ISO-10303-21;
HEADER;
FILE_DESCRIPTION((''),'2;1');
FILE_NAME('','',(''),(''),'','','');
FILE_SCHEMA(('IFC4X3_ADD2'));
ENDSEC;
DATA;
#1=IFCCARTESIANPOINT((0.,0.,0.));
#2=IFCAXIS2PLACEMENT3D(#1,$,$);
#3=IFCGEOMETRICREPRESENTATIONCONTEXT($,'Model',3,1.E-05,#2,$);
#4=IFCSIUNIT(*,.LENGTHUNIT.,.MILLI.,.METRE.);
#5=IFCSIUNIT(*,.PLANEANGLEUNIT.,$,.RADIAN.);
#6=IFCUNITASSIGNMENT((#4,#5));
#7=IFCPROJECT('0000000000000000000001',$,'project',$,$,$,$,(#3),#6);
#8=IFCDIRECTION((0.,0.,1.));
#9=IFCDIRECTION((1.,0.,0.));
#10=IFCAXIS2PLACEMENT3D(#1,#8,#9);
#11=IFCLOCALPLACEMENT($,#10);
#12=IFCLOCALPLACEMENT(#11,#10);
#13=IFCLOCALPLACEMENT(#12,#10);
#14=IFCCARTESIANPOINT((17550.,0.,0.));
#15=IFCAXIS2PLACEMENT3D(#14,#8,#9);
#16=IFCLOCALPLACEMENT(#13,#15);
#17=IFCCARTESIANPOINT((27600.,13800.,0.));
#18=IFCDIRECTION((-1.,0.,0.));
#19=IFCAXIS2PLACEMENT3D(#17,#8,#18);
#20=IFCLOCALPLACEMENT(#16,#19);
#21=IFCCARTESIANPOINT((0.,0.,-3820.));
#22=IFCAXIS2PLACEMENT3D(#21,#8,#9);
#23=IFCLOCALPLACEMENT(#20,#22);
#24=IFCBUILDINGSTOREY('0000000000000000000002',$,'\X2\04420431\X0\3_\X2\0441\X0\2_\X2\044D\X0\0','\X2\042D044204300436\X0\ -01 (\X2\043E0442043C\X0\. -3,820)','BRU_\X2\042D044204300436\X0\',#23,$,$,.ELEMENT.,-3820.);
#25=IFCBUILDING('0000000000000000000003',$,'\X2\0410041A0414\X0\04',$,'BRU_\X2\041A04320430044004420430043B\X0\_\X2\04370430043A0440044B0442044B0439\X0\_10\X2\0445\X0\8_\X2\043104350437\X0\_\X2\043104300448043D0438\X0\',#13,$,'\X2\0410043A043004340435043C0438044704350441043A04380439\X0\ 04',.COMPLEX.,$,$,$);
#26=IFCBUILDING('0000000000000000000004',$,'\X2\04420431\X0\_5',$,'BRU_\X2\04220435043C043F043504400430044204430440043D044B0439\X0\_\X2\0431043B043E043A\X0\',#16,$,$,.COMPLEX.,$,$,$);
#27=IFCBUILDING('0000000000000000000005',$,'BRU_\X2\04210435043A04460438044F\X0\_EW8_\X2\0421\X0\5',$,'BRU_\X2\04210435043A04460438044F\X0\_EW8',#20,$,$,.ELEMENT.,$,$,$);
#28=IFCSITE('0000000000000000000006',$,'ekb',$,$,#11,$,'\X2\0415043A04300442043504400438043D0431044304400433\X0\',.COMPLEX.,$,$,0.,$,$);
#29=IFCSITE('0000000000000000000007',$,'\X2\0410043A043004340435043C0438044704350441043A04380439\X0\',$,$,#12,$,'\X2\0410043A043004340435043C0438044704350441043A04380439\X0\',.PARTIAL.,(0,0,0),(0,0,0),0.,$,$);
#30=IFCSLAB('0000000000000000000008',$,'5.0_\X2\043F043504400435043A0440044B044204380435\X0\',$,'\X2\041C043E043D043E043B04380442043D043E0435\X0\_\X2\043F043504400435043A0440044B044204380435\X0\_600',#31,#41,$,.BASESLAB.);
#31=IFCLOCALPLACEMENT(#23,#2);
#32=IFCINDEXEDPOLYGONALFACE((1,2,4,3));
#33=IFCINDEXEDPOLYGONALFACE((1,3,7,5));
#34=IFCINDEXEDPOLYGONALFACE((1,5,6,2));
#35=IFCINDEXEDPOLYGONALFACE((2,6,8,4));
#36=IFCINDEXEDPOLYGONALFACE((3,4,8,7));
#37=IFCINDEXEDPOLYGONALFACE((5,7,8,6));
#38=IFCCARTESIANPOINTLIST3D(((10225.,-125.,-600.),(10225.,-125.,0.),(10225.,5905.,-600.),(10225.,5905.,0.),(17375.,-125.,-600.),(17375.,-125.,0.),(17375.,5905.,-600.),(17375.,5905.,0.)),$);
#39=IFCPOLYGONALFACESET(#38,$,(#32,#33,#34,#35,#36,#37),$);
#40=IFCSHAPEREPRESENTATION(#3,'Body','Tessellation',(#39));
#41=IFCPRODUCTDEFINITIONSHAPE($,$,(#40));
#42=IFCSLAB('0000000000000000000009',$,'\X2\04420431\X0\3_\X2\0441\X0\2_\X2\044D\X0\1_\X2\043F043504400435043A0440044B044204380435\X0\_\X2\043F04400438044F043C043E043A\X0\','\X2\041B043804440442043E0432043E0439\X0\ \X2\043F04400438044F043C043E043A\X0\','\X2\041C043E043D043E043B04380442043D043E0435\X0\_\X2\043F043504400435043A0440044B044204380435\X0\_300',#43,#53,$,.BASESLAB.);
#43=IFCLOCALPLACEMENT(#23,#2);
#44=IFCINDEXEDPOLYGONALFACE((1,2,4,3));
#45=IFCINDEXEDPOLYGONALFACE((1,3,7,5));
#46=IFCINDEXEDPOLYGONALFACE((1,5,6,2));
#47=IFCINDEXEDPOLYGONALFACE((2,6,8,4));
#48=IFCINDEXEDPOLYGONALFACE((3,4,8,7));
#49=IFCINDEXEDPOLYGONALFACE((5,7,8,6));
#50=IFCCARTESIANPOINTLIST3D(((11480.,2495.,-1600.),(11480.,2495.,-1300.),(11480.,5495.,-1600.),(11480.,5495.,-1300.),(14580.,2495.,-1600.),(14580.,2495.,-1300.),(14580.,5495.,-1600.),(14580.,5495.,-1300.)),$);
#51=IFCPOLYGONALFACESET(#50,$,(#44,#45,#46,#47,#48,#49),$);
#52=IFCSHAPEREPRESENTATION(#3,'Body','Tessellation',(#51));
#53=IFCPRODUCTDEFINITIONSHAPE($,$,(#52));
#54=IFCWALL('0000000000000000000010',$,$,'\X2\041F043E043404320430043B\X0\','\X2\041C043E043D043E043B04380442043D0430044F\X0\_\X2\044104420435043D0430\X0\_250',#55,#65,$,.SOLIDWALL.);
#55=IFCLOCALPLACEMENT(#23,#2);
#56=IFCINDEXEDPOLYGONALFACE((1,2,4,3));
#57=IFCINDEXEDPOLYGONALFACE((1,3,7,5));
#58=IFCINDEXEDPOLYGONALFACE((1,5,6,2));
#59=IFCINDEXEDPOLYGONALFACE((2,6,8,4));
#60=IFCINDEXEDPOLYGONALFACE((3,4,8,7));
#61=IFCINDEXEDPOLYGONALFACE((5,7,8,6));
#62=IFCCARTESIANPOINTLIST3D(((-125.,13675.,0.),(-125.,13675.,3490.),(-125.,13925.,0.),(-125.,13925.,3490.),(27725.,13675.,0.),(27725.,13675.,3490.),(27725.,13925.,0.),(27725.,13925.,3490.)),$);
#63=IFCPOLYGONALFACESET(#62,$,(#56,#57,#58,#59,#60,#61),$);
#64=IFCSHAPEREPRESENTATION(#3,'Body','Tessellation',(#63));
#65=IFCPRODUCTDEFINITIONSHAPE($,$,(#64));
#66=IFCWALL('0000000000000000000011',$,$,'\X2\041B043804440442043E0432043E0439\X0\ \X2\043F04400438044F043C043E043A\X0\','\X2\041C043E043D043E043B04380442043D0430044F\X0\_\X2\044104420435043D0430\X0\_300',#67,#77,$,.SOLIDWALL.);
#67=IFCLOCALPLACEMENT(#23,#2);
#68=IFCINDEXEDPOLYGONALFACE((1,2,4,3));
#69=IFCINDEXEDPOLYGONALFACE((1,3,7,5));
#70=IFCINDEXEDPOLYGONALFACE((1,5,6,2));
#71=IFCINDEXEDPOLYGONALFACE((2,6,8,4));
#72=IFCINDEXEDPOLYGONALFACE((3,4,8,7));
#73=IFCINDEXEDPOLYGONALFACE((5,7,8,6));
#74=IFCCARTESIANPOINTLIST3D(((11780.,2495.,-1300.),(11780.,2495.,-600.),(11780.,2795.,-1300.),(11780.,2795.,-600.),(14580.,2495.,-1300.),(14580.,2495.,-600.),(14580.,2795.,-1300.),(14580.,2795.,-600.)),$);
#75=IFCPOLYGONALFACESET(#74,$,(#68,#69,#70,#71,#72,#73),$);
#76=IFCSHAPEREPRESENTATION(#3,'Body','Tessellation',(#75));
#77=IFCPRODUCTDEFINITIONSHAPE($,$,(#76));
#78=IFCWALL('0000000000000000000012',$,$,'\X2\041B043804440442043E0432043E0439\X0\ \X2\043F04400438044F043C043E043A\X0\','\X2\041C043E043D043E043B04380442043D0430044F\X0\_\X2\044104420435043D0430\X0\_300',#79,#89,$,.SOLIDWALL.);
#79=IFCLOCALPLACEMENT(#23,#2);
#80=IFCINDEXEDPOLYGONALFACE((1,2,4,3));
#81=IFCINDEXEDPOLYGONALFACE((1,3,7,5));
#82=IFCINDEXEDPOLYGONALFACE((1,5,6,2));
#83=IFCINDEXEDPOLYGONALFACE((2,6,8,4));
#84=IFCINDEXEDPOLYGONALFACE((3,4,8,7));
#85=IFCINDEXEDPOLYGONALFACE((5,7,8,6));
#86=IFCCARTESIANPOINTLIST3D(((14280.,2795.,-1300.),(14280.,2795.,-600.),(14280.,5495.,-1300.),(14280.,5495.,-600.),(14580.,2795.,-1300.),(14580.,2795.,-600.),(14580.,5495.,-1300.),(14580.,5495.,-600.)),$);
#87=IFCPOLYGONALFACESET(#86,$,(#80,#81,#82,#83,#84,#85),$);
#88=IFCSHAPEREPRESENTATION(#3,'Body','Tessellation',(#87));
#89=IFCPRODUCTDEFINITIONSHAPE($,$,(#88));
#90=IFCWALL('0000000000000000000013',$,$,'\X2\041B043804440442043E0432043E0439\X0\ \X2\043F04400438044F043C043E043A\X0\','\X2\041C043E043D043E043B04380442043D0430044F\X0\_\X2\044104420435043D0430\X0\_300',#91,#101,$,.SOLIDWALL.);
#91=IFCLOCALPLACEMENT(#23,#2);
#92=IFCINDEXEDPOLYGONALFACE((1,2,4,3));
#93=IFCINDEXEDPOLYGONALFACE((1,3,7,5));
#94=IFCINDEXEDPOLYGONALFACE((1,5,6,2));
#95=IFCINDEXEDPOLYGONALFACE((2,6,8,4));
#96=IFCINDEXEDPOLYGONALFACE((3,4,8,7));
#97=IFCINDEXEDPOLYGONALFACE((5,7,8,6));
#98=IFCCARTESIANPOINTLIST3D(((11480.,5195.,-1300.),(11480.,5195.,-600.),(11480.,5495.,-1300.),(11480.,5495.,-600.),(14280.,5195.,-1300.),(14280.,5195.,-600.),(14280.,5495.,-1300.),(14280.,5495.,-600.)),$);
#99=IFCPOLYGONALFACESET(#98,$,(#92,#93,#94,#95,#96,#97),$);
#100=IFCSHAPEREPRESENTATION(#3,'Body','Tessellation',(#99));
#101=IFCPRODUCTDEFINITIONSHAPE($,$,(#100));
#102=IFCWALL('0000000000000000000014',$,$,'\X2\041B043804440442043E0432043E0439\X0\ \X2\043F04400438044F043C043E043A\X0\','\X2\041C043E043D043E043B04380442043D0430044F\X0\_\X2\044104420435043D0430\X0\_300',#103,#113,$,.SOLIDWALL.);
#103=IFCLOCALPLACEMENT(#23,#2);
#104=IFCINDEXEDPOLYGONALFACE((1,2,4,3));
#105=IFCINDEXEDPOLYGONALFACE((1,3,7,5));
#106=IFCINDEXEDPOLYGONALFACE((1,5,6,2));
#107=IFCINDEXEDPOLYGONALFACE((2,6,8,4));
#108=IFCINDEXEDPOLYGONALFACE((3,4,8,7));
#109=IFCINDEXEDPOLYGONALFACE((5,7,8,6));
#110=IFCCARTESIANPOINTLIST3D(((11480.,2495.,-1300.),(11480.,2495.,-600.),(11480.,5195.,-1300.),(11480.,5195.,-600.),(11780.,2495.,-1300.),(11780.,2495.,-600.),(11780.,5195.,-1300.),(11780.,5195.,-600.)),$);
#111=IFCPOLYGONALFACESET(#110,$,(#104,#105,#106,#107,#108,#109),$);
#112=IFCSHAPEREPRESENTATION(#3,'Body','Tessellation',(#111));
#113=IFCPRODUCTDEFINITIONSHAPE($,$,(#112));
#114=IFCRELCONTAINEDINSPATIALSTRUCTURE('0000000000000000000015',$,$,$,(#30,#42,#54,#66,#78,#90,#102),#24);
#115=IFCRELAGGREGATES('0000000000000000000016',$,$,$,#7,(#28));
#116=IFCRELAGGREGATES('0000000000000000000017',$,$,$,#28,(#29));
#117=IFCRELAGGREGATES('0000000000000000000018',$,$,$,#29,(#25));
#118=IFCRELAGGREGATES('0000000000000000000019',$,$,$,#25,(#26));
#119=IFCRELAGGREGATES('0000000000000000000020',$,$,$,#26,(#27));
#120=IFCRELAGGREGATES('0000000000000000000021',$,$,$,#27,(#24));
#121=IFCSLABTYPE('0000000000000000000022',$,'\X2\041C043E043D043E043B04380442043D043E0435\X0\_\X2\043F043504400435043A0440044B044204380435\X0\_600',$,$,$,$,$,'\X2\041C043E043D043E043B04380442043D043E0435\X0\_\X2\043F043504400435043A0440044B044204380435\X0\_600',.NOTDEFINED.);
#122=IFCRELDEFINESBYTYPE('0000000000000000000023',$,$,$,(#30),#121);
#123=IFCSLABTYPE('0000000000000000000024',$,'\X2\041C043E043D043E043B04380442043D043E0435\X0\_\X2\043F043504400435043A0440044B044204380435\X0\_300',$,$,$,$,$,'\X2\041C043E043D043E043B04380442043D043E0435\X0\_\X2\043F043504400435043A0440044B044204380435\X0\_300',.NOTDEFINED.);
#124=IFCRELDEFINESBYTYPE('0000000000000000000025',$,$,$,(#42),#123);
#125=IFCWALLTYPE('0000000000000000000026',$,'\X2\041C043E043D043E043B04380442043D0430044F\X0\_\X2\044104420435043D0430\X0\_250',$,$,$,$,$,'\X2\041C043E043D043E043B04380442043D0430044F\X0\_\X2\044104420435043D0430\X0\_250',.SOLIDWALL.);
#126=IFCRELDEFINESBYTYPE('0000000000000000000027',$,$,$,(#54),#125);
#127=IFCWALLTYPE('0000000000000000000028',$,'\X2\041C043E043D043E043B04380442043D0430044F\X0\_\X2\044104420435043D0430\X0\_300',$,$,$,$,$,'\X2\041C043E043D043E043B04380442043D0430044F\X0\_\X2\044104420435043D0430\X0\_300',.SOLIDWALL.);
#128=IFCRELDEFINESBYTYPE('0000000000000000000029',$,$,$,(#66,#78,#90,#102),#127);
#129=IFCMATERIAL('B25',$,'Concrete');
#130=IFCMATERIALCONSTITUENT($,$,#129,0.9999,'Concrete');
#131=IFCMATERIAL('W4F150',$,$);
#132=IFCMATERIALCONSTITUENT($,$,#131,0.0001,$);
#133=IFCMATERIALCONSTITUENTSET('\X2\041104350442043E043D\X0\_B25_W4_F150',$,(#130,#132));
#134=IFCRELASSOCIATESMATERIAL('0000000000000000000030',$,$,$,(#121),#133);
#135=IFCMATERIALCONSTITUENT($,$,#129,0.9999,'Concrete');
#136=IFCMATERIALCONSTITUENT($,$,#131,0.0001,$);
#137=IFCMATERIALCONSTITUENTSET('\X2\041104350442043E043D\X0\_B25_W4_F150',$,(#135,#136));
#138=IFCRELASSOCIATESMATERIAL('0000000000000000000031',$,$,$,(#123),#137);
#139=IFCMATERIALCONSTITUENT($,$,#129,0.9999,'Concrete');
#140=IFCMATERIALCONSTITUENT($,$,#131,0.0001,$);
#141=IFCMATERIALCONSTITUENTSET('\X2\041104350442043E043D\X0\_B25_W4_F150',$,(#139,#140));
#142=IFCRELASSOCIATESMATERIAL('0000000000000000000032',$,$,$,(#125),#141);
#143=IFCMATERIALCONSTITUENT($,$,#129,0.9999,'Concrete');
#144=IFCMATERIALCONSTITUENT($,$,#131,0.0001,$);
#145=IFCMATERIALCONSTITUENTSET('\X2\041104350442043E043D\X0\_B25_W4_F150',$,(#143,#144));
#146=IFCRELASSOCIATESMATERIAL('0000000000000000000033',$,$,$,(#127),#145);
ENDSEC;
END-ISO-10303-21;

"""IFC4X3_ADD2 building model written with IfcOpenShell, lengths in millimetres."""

from ifc_helpers import new_model, si_unit, frame, origin, origin_with_axes, origin_2d_with_axis, place, context, project, spatial, polyline, rectangle, outline, extrude, material, constituent, constituent_set, type_object, element, save


model = new_model("IFC4X3_ADD2")

# Units and contexts
model_context = context("Model", 3, precision=1e-05, world=origin())
ifc_project = project(units=[si_unit("LENGTHUNIT", "METRE", prefix="MILLI"), si_unit("PLANEANGLEUNIT", "RADIAN")], contexts=[model_context])

# Sites, buildings, storey
site_1_placement = place(None, origin_with_axes())
site_1 = spatial("IfcSite", under=ifc_project, at=site_1_placement, Name="ekb", LongName="Екатеринбург", CompositionType="COMPLEX", RefElevation=0.0)
site_2_placement = place(site_1_placement, origin_with_axes())
site_2 = spatial("IfcSite", under=site_1, at=site_2_placement, Name="Академический", LongName="Академический", CompositionType="PARTIAL", RefLatitude=(0, 0, 0), RefLongitude=(0, 0, 0), RefElevation=0.0)
building_1_placement = place(site_2_placement, origin_with_axes())
building_1 = spatial("IfcBuilding", under=site_2, at=building_1_placement, Name="АКД04", ObjectType="BRU_Квартал_закрытый_10х8_без_башни", LongName="Академический 04", CompositionType="COMPLEX")
building_2_placement = place(building_1_placement, frame((17550.0, 0.0, 0.0), z_axis=(0.0, 0.0, 1.0), x_axis=(1.0, 0.0, 0.0)))
building_2 = spatial("IfcBuilding", under=building_1, at=building_2_placement, Name="тб_5", ObjectType="BRU_Температурный_блок", CompositionType="COMPLEX")
building_3_placement = place(building_2_placement, frame((27600.0, 13800.0, 0.0), z_axis=(0.0, 0.0, 1.0), x_axis=(-1.0, 0.0, 0.0)))
building_3 = spatial("IfcBuilding", under=building_2, at=building_3_placement, Name="BRU_Секция_EW8_С5", ObjectType="BRU_Секция_EW8", CompositionType="ELEMENT")
storey_placement = place(building_3_placement, frame((0.0, 0.0, -3820.0), z_axis=(0.0, 0.0, 1.0), x_axis=(1.0, 0.0, 0.0)))
storey = spatial("IfcBuildingStorey", under=building_3, at=storey_placement, Name="тб3_с2_э0", Description="Этаж -01 (отм. -3,820)", ObjectType="BRU_Этаж", CompositionType="ELEMENT", Elevation=-3820.0)

# Shared definitions
ifc_material_1 = material(Name="B25", Category="Concrete")
ifc_material_2 = material(Name="W4F150")

# Slabs
ifc_constituent_1 = constituent(ifc_material_1, Category="Concrete", fraction=0.9999)
ifc_constituent_2 = constituent(ifc_material_2, fraction=0.0001)
ifc_constituent_set_1 = constituent_set(constituents=[ifc_constituent_1, ifc_constituent_2], Name="Бетон_B25_W4_F150")
slab_type_1 = type_object("IfcSlabType", Name="Монолитное_перекрытие_600", ElementType="Монолитное_перекрытие_600", PredefinedType="NOTDEFINED", material=ifc_constituent_set_1)
slab_1_placement = place(storey_placement, frame((0.0, 0.0, -600.0), z_axis=(0.0, 0.0, 1.0), x_axis=(1.0, 0.0, 0.0)))
element("IfcSlab", 1, at=slab_1_placement, inside=storey, type_object=slab_type_1, Name="5.0_перекрытие", ObjectType="Монолитное_перекрытие_600", PredefinedType="BASESLAB", context=model_context, shape_type="SweptSolid", body=[
    extrude(outline(polyline([(17375.0, 5905.0), (10225.0, 5905.0), (10225.0, -125.0), (17375.0, -125.0), (17375.0, 5905.0)])), origin_with_axes(), (0.0, 0.0, 1.0), 600.0),
])
ifc_constituent_3 = constituent(ifc_material_1, Category="Concrete", fraction=0.9999)
ifc_constituent_4 = constituent(ifc_material_2, fraction=0.0001)
ifc_constituent_set_2 = constituent_set(constituents=[ifc_constituent_3, ifc_constituent_4], Name="Бетон_B25_W4_F150")
slab_type_2 = type_object("IfcSlabType", Name="Монолитное_перекрытие_300", ElementType="Монолитное_перекрытие_300", PredefinedType="NOTDEFINED", material=ifc_constituent_set_2)
slab_2_placement = place(storey_placement, frame((13030.0, 3995.0, -1600.0), z_axis=(0.0, 0.0, 1.0), x_axis=(1.0, 0.0, 0.0)))
element("IfcSlab", 2, at=slab_2_placement, inside=storey, type_object=slab_type_2, Name="тб3_с2_э1_перекрытие_приямок", Description="Лифтовой приямок", ObjectType="Монолитное_перекрытие_300", PredefinedType="BASESLAB", context=model_context, shape_type="SweptSolid", body=[
    extrude(outline(polyline([(-1550.0, -1500.0), (-1550.0, 1500.0), (1550.0, 1500.0), (1550.0, -1500.0), (-1550.0, -1500.0)])), origin_with_axes(), (0.0, 0.0, 1.0), 300.0),
])

# Walls
ifc_constituent_5 = constituent(ifc_material_1, Category="Concrete", fraction=0.9999)
ifc_constituent_6 = constituent(ifc_material_2, fraction=0.0001)
ifc_constituent_set_3 = constituent_set(constituents=[ifc_constituent_5, ifc_constituent_6], Name="Бетон_B25_W4_F150")
wall_type_1 = type_object("IfcWallType", Name="Монолитная_стена_250", ElementType="Монолитная_стена_250", PredefinedType="SOLIDWALL", material=ifc_constituent_set_3)
wall_1_placement = place(storey_placement, frame((-125.0, 13800.0, 0.0), z_axis=(0.0, 0.0, 1.0), x_axis=(1.0, 0.0, 0.0)))
element("IfcWall", 3, at=wall_1_placement, inside=storey, type_object=wall_type_1, Description="Подвал", ObjectType="Монолитная_стена_250", PredefinedType="SOLIDWALL", context=model_context, shape_type="SweptSolid", body=[
    extrude(rectangle(XDim=27850.0, YDim=250.0, at=origin_2d_with_axis()), frame((13925.0, 0.0, 0.0), z_axis=(0.0, 0.0, 1.0), x_axis=(1.0, 0.0, 0.0)), (0.0, 0.0, 1.0), 3490.0),
])
ifc_constituent_7 = constituent(ifc_material_1, Category="Concrete", fraction=0.9999)
ifc_constituent_8 = constituent(ifc_material_2, fraction=0.0001)
ifc_constituent_set_4 = constituent_set(constituents=[ifc_constituent_7, ifc_constituent_8], Name="Бетон_B25_W4_F150")
wall_type_2 = type_object("IfcWallType", Name="Монолитная_стена_300", ElementType="Монолитная_стена_300", PredefinedType="SOLIDWALL", material=ifc_constituent_set_4)
wall_2_placement = place(storey_placement, frame((11780.0, 2645.0, -1300.0), z_axis=(0.0, 0.0, 1.0), x_axis=(1.0, 0.0, 0.0)))
element("IfcWall", 4, at=wall_2_placement, inside=storey, type_object=wall_type_2, Description="Лифтовой приямок", ObjectType="Монолитная_стена_300", PredefinedType="SOLIDWALL", context=model_context, shape_type="SweptSolid", body=[
    extrude(rectangle(XDim=2800.0, YDim=300.0, at=origin_2d_with_axis()), frame((1400.0, 0.0, 0.0), z_axis=(0.0, 0.0, 1.0), x_axis=(1.0, 0.0, 0.0)), (0.0, 0.0, 1.0), 700.0),
])
wall_3_placement = place(storey_placement, frame((14430.0, 2795.0, -1300.0), z_axis=(0.0, 0.0, 1.0), x_axis=(0.0, 1.0, 0.0)))
element("IfcWall", 5, at=wall_3_placement, inside=storey, type_object=wall_type_2, Description="Лифтовой приямок", ObjectType="Монолитная_стена_300", PredefinedType="SOLIDWALL", context=model_context, shape_type="SweptSolid", body=[
    extrude(rectangle(XDim=2700.0, YDim=300.0, at=origin_2d_with_axis()), frame((1350.0, 0.0, 0.0), z_axis=(0.0, 0.0, 1.0), x_axis=(1.0, 0.0, 0.0)), (0.0, 0.0, 1.0), 700.0),
])
wall_4_placement = place(storey_placement, frame((14280.0, 5345.0, -1300.0), z_axis=(0.0, 0.0, 1.0), x_axis=(-1.0, 0.0, 0.0)))
element("IfcWall", 6, at=wall_4_placement, inside=storey, type_object=wall_type_2, Description="Лифтовой приямок", ObjectType="Монолитная_стена_300", PredefinedType="SOLIDWALL", context=model_context, shape_type="SweptSolid", body=[
    extrude(rectangle(XDim=2800.0, YDim=300.0, at=origin_2d_with_axis()), frame((1400.0, 0.0, 0.0), z_axis=(0.0, 0.0, 1.0), x_axis=(1.0, 0.0, 0.0)), (0.0, 0.0, 1.0), 700.0),
])
wall_5_placement = place(storey_placement, frame((11630.0, 5195.0, -1300.0), z_axis=(0.0, 0.0, 1.0), x_axis=(0.0, -1.0, 0.0)))
element("IfcWall", 7, at=wall_5_placement, inside=storey, type_object=wall_type_2, Description="Лифтовой приямок", ObjectType="Монолитная_стена_300", PredefinedType="SOLIDWALL", context=model_context, shape_type="SweptSolid", body=[
    extrude(rectangle(XDim=2700.0, YDim=300.0, at=origin_2d_with_axis()), frame((1350.0, 0.0, 0.0), z_axis=(0.0, 0.0, 1.0), x_axis=(1.0, 0.0, 0.0)), (0.0, 0.0, 1.0), 700.0),
])

save(model, "model.ifc")
